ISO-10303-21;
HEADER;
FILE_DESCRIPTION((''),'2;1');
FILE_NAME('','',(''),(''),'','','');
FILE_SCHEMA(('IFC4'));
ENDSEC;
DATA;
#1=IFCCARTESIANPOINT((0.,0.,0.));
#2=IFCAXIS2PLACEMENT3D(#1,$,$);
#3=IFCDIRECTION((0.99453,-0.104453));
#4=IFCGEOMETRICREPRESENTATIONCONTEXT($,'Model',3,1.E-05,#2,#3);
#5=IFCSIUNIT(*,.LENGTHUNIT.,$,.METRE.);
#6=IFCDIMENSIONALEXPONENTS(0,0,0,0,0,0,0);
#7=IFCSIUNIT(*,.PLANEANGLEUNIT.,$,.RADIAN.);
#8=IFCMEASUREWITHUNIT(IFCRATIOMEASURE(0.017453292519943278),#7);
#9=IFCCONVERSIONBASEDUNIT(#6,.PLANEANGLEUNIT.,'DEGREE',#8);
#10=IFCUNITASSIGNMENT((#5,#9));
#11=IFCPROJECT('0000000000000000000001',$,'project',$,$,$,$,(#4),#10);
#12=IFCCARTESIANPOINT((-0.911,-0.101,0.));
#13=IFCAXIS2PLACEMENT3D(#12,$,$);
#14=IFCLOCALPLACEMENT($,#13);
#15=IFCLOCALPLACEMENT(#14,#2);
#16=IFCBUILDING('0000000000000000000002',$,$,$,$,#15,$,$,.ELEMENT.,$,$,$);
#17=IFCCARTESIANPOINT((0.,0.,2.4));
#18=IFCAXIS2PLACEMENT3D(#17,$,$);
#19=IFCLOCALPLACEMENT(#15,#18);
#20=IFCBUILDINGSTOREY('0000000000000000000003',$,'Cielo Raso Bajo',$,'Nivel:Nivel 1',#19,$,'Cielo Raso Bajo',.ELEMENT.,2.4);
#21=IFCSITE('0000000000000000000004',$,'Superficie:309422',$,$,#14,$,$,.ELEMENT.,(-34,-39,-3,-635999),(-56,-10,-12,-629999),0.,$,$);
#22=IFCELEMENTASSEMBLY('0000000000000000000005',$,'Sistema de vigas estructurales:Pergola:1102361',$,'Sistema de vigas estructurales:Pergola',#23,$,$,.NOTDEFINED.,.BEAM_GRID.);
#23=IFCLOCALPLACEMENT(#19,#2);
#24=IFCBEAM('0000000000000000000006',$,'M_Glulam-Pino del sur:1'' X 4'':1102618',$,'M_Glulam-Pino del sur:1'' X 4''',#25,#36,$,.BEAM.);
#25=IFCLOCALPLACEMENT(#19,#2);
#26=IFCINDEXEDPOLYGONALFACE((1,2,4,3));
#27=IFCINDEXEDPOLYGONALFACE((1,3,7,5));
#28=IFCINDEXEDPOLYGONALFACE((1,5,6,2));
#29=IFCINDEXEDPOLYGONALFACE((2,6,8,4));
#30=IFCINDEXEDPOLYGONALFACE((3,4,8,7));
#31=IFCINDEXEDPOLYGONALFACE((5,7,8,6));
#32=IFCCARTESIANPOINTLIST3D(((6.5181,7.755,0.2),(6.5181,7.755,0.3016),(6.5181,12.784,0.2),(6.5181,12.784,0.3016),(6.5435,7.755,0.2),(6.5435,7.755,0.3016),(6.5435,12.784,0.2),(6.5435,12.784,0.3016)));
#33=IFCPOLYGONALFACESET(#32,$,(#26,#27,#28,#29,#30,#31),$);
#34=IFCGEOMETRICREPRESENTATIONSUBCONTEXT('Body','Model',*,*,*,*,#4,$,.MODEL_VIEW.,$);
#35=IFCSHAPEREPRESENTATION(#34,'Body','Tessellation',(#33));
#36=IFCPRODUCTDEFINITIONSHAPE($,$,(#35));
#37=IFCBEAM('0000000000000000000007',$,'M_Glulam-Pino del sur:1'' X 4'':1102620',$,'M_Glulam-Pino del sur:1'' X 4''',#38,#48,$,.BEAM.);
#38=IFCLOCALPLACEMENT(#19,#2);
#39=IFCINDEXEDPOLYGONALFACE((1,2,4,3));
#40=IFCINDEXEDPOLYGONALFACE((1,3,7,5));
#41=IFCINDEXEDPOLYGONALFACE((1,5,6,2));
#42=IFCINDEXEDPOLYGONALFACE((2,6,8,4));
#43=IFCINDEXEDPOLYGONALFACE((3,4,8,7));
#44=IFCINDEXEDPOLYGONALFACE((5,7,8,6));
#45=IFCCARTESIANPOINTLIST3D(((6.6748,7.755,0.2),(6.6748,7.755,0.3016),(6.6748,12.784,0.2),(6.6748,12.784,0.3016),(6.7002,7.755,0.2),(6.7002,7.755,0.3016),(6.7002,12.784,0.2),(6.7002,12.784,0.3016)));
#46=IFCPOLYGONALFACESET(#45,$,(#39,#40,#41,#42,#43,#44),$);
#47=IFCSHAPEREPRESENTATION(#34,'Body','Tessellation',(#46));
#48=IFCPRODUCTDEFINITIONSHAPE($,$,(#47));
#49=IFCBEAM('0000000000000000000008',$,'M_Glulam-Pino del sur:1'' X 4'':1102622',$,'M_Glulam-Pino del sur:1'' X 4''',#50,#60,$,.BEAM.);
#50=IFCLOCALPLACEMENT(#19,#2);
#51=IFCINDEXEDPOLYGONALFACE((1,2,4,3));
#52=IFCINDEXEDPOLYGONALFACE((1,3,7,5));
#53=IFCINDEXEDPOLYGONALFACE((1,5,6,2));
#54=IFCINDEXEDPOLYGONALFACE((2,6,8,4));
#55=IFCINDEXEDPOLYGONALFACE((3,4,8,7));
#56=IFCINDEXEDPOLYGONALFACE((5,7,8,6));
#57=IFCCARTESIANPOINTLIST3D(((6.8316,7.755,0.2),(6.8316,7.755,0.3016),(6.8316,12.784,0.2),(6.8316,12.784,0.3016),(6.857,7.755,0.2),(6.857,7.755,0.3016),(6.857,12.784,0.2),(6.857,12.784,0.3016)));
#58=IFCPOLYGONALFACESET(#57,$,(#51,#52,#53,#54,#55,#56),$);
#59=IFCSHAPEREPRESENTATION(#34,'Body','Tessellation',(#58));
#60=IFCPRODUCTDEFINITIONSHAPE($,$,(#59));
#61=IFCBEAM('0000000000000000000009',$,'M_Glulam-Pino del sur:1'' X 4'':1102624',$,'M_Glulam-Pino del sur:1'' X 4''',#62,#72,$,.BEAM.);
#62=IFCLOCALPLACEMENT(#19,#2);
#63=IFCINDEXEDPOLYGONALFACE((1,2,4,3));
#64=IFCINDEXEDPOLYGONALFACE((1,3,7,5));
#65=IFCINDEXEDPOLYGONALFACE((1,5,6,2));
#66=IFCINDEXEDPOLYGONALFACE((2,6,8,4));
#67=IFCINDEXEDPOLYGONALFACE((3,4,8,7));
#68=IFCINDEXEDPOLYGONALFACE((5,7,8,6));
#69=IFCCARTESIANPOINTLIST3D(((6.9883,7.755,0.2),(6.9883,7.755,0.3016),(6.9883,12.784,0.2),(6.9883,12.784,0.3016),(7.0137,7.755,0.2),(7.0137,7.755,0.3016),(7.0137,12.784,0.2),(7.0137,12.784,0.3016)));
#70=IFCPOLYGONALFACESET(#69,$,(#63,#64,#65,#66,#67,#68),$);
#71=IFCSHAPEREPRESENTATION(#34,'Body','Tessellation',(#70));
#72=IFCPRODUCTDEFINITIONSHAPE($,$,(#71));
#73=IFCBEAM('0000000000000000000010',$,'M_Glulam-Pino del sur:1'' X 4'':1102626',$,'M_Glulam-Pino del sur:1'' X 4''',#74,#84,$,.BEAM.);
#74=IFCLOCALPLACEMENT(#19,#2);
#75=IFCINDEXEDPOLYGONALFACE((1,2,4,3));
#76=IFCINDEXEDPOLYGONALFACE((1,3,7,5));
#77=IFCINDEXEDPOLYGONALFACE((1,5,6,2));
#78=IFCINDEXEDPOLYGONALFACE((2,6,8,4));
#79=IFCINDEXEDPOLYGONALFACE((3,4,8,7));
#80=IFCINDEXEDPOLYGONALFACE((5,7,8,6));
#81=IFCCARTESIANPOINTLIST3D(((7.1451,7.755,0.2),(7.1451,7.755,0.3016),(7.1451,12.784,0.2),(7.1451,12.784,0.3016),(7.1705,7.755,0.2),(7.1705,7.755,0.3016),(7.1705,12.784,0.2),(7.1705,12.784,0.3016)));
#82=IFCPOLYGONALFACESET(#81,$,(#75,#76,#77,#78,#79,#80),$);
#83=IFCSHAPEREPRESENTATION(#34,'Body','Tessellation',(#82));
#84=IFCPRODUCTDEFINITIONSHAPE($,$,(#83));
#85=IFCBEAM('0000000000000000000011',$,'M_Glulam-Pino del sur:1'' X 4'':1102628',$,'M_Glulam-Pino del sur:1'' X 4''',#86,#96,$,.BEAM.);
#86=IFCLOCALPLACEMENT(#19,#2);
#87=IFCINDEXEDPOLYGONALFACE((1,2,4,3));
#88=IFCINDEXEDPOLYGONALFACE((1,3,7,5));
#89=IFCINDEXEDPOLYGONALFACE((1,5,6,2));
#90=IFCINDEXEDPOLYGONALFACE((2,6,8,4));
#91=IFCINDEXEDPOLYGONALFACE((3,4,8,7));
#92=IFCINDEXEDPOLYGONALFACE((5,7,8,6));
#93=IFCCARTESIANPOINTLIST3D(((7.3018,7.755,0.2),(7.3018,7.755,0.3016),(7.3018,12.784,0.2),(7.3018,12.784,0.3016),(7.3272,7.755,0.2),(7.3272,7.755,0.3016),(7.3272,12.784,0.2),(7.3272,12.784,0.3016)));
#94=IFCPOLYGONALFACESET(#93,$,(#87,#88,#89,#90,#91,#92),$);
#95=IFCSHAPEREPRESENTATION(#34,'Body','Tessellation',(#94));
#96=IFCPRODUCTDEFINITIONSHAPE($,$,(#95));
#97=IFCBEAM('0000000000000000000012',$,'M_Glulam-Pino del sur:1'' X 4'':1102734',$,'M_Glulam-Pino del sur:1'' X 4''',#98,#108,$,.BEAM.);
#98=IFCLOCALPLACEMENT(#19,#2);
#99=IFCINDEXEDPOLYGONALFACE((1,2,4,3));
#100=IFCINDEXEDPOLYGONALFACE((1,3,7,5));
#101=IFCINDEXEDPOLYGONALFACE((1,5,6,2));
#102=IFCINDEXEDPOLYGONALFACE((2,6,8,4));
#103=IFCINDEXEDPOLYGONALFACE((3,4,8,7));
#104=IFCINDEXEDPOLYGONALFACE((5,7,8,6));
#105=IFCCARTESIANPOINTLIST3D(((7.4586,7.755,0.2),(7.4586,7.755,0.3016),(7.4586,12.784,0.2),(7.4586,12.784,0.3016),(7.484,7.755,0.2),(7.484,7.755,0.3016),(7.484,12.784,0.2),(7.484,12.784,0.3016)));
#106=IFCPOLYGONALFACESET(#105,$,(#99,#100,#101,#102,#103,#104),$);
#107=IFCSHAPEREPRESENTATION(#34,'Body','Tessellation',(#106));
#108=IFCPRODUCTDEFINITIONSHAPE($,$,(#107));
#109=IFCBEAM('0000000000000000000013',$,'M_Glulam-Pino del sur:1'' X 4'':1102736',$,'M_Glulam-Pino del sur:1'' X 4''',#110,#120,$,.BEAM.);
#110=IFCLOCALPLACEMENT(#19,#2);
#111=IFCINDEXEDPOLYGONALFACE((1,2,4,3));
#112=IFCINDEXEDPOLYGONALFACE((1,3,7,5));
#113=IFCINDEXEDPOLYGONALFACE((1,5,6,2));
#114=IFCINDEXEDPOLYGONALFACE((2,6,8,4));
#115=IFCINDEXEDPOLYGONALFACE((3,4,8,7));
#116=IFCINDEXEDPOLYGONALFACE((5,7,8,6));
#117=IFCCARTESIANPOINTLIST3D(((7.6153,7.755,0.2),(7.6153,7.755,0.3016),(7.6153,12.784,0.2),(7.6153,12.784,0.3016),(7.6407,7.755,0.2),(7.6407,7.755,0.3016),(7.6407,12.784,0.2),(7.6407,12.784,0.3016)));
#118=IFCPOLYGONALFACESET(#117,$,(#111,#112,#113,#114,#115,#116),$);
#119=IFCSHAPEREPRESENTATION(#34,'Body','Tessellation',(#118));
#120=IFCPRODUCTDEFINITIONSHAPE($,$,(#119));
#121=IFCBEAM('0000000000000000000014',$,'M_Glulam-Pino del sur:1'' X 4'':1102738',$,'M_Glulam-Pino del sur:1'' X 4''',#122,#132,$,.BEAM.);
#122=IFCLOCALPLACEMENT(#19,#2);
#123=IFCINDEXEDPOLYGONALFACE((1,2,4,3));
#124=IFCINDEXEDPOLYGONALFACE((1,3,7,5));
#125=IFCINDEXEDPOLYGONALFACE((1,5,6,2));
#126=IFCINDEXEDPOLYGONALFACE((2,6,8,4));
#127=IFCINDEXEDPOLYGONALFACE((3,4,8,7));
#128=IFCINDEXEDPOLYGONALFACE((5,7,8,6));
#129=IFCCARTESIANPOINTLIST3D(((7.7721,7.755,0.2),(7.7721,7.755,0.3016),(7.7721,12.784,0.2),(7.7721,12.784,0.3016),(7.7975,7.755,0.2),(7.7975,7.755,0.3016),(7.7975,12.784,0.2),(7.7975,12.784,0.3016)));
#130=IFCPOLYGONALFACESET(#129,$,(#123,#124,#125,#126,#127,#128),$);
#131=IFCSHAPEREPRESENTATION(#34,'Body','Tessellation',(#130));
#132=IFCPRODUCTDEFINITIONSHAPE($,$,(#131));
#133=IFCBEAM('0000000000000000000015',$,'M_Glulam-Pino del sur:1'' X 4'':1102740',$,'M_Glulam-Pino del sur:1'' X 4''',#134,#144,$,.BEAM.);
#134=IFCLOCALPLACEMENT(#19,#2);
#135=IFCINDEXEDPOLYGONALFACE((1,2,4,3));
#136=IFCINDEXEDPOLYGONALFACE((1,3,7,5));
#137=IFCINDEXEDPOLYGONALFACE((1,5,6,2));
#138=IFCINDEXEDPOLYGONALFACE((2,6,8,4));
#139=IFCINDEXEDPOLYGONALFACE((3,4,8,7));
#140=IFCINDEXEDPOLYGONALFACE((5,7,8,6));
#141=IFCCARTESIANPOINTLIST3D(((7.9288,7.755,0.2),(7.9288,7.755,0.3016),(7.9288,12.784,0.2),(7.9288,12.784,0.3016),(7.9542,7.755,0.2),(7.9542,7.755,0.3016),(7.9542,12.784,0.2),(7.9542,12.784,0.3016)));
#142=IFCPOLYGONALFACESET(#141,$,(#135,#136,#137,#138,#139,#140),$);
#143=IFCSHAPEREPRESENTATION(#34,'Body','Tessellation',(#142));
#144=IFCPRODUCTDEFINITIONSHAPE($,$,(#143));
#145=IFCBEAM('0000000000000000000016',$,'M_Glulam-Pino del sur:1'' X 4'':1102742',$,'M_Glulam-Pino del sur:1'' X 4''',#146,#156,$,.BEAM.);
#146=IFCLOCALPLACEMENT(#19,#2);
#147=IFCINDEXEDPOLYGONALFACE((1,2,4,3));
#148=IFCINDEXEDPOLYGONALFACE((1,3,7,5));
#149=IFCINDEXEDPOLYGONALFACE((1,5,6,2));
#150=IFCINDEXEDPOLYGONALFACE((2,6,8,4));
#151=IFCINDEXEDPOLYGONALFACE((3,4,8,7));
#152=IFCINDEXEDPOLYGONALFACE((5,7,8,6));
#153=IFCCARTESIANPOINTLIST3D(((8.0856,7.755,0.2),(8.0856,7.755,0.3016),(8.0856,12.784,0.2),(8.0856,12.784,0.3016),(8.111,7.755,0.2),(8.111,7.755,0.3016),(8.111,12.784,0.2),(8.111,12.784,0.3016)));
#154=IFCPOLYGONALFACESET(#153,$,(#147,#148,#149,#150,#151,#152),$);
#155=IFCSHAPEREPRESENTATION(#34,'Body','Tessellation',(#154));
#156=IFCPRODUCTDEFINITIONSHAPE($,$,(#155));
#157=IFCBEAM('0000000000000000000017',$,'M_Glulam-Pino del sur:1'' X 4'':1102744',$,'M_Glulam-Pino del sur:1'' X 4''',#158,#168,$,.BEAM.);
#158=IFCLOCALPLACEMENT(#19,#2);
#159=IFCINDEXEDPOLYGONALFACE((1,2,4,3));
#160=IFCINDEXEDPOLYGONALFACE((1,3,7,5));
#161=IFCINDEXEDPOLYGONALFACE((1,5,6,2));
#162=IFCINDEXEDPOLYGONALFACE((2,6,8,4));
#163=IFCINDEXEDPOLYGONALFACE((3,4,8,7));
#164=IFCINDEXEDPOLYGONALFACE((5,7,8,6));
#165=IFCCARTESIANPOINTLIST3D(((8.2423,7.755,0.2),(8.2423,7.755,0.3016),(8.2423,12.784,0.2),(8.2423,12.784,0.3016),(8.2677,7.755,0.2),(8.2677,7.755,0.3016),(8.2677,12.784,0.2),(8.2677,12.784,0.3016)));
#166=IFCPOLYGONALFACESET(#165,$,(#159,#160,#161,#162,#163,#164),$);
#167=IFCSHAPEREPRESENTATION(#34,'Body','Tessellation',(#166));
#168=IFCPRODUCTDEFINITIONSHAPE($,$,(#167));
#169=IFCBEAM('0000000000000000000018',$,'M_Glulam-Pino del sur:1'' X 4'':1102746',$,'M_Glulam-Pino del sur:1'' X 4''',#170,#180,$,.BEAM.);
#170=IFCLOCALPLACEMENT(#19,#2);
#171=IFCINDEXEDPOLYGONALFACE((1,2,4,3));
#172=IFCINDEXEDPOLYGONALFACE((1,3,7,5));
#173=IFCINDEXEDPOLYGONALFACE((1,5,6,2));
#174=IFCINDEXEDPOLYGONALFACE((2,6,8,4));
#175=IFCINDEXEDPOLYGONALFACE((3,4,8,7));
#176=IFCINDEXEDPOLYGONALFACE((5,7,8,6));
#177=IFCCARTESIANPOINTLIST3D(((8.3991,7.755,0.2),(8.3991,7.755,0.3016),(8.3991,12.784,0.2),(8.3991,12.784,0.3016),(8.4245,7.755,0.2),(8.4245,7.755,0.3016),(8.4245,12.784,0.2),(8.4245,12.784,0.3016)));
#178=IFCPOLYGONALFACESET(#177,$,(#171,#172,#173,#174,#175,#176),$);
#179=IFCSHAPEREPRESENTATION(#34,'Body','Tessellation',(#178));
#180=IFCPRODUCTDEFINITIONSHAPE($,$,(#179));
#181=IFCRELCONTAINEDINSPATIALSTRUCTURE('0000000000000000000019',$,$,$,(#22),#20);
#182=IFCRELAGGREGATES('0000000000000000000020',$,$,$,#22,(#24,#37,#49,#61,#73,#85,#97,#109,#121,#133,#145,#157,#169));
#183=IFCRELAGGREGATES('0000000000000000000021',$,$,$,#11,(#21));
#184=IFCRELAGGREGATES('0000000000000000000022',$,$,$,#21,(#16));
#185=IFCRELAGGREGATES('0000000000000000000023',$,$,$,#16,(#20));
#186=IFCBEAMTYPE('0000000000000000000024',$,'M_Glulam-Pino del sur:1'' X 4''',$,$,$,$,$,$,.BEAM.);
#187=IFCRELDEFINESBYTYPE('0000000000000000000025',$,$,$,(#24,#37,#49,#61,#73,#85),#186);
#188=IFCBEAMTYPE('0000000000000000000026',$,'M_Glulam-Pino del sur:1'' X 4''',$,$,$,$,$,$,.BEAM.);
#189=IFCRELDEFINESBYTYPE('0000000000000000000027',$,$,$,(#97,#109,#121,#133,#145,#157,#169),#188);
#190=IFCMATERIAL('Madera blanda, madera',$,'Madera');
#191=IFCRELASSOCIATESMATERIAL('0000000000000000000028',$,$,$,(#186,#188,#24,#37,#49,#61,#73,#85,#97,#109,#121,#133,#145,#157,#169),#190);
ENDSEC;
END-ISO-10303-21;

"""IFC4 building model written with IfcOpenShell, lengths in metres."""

from ifc_helpers import new_model, entity, si_unit, converted_unit, direction, frame, origin, origin_2d_with_axis, place, context, subcontext, project, spatial, polyline, segment, composite_curve, rectangle, outline, extrude, source, transform, mapped, material, material_profile, profile_set, profile_usage, type_object, type_shapes, element, aggregate, save


model = new_model("IFC4")

# Units and contexts
model_context = context("Model", 3, precision=1e-05, world=origin(), true_north=direction((0.99453, -0.104453)))
body_context = subcontext(model_context, "Body", "Model", "MODEL_VIEW")
ifc_project = project(units=[si_unit("LENGTHUNIT", "METRE"), converted_unit("PLANEANGLEUNIT", "DEGREE", entity("IfcRatioMeasure", 0.017453292519943278), si_unit("PLANEANGLEUNIT", "RADIAN"), dimensions=[0, 0, 0, 0, 0, 0, 0])], contexts=[model_context])

# Site, building, storey
site_placement = place(None, frame((-0.911, -0.101, 0.0)))
site = spatial("IfcSite", under=ifc_project, at=site_placement, Name="Superficie:309422", CompositionType="ELEMENT", RefLatitude=(-34, -39, -3, -635999), RefLongitude=(-56, -10, -12, -629999), RefElevation=0.0)
building_placement = place(site_placement, origin())
building = spatial("IfcBuilding", under=site, at=building_placement, CompositionType="ELEMENT")
storey_placement = place(building_placement, frame((0.0, 0.0, 2.4)))
storey = spatial("IfcBuildingStorey", under=building, at=storey_placement, Name="Cielo Raso Bajo", ObjectType="Nivel:Nivel 1", LongName="Cielo Raso Bajo", CompositionType="ELEMENT", Elevation=2.4)

# Element assembly, beams
assembly_placement = place(storey_placement, origin())
assembly = element("IfcElementAssembly", 1, at=assembly_placement, inside=storey, Name="Sistema de vigas estructurales:Pergola:1102361", ObjectType="Sistema de vigas estructurales:Pergola", AssemblyPlace="NOTDEFINED", PredefinedType="BEAM_GRID")
ifc_material_1 = material(Name="Madera blanda, madera", Category="Madera")
ifc_material_profile_1 = material_profile(ifc_material_1, outline(composite_curve([segment(polyline([(-0.0127, 0.0508, 0.0), (0.0127, 0.0508, 0.0)]), True, "CONTINUOUS"), segment(polyline([(0.0127, 0.0508, 0.0), (0.0127, -0.0508, 0.0)]), True, "CONTINUOUS"), segment(polyline([(0.0127, -0.0508, 0.0), (-0.0127, -0.0508, 0.0)]), True, "CONTINUOUS"), segment(polyline([(-0.0127, -0.0508, 0.0), (-0.0127, 0.0508, 0.0)]), True, "CONTINUOUS")], self_intersect=False), kind="CURVE"), Name="1' X 4'")
ifc_material_profile_2 = material_profile(ifc_material_1, outline(composite_curve([segment(polyline([(2.5145, -0.0127, -0.0508), (2.5145, -0.0127, 0.0508)]), True, "CONTINUOUS"), segment(polyline([(2.5145, -0.0127, 0.0508), (-2.5145, -0.0127, 0.0508)]), True, "CONTINUOUS"), segment(polyline([(-2.5145, -0.0127, 0.0508), (-2.5145, -0.0127, -0.0508)]), True, "CONTINUOUS"), segment(polyline([(-2.5145, -0.0127, -0.0508), (2.5145, -0.0127, -0.0508)]), True, "CONTINUOUS")], self_intersect=False), kind="CURVE"), Name="1' X 4'")
ifc_profile_set_1 = profile_set([ifc_material_profile_1, ifc_material_profile_2], Name="1' X 4'")
ifc_profile_usage_1 = profile_usage(ifc_profile_set_1, cardinal=8)
beam_type_1 = type_object("IfcBeamType", Name="M_Glulam-Pino del sur:1' X 4'", PredefinedType="BEAM", material=ifc_profile_set_1)
shared_shape_1 = source(origin(), body_context, "Body", "SweptSolid", [
    extrude(rectangle(XDim=0.1016, YDim=0.0254, at=origin_2d_with_axis()), frame((-2.5145, 0.0, 0.0), z_axis=(1.0, 0.0, 0.0), x_axis=(0.0, 0.0, -1.0)), (0.0, 0.0, 1.0), 5.029),
])
type_shapes(beam_type_1, [shared_shape_1])
beam_1_placement = place(assembly_placement, frame((6.5308, 10.2695, 0.2508), z_axis=(0.0, 0.0, 1.0), x_axis=(0.0, 1.0, 0.0)))
beam_1 = element("IfcBeam", 2, at=beam_1_placement, type_object=beam_type_1, material=ifc_profile_usage_1, Name="M_Glulam-Pino del sur:1' X 4':1102618", ObjectType="M_Glulam-Pino del sur:1' X 4'", PredefinedType="BEAM", context=body_context, shape_type="MappedRepresentation", body=[
    mapped(shared_shape_1, transform((0.0, 0.0, 0.0), scale=1.0)),
])
ifc_profile_usage_2 = profile_usage(ifc_profile_set_1, cardinal=8)
beam_2_placement = place(assembly_placement, frame((6.6875, 10.2695, 0.2508), z_axis=(0.0, 0.0, 1.0), x_axis=(0.0, 1.0, 0.0)))
beam_2 = element("IfcBeam", 3, at=beam_2_placement, type_object=beam_type_1, material=ifc_profile_usage_2, Name="M_Glulam-Pino del sur:1' X 4':1102620", ObjectType="M_Glulam-Pino del sur:1' X 4'", PredefinedType="BEAM", context=body_context, shape_type="MappedRepresentation", body=[
    mapped(shared_shape_1, transform((0.0, 0.0, 0.0), scale=1.0)),
])
ifc_profile_usage_3 = profile_usage(ifc_profile_set_1, cardinal=8)
beam_3_placement = place(assembly_placement, frame((6.8443, 10.2695, 0.2508), z_axis=(0.0, 0.0, 1.0), x_axis=(0.0, 1.0, 0.0)))
beam_3 = element("IfcBeam", 4, at=beam_3_placement, type_object=beam_type_1, material=ifc_profile_usage_3, Name="M_Glulam-Pino del sur:1' X 4':1102622", ObjectType="M_Glulam-Pino del sur:1' X 4'", PredefinedType="BEAM", context=body_context, shape_type="MappedRepresentation", body=[
    mapped(shared_shape_1, transform((0.0, 0.0, 0.0), scale=1.0)),
])
ifc_profile_usage_4 = profile_usage(ifc_profile_set_1, cardinal=8)
beam_4_placement = place(assembly_placement, frame((7.001, 10.2695, 0.2508), z_axis=(0.0, 0.0, 1.0), x_axis=(0.0, 1.0, 0.0)))
beam_4 = element("IfcBeam", 5, at=beam_4_placement, type_object=beam_type_1, material=ifc_profile_usage_4, Name="M_Glulam-Pino del sur:1' X 4':1102624", ObjectType="M_Glulam-Pino del sur:1' X 4'", PredefinedType="BEAM", context=body_context, shape_type="MappedRepresentation", body=[
    mapped(shared_shape_1, transform((0.0, 0.0, 0.0), scale=1.0)),
])
ifc_profile_usage_5 = profile_usage(ifc_profile_set_1, cardinal=8)
beam_5_placement = place(assembly_placement, frame((7.1578, 10.2695, 0.2508), z_axis=(0.0, 0.0, 1.0), x_axis=(0.0, 1.0, 0.0)))
beam_5 = element("IfcBeam", 6, at=beam_5_placement, type_object=beam_type_1, material=ifc_profile_usage_5, Name="M_Glulam-Pino del sur:1' X 4':1102626", ObjectType="M_Glulam-Pino del sur:1' X 4'", PredefinedType="BEAM", context=body_context, shape_type="MappedRepresentation", body=[
    mapped(shared_shape_1, transform((0.0, 0.0, 0.0), scale=1.0)),
])
ifc_profile_usage_6 = profile_usage(ifc_profile_set_1, cardinal=8)
beam_6_placement = place(assembly_placement, frame((7.3145, 10.2695, 0.2508), z_axis=(0.0, 0.0, 1.0), x_axis=(0.0, 1.0, 0.0)))
beam_6 = element("IfcBeam", 7, at=beam_6_placement, type_object=beam_type_1, material=ifc_profile_usage_6, Name="M_Glulam-Pino del sur:1' X 4':1102628", ObjectType="M_Glulam-Pino del sur:1' X 4'", PredefinedType="BEAM", context=body_context, shape_type="MappedRepresentation", body=[
    mapped(shared_shape_1, transform((0.0, 0.0, 0.0), scale=1.0)),
])
ifc_profile_usage_7 = profile_usage(ifc_profile_set_1, cardinal=8)
beam_type_2 = type_object("IfcBeamType", Name="M_Glulam-Pino del sur:1' X 4'", PredefinedType="BEAM", material=ifc_profile_set_1)
shared_shape_2 = source(origin(), body_context, "Body", "SweptSolid", [
    extrude(rectangle(XDim=0.1016, YDim=0.0254, at=origin_2d_with_axis()), frame((-2.4455, 0.0, 0.0), z_axis=(1.0, 0.0, 0.0), x_axis=(0.0, 0.0, -1.0)), (0.0, 0.0, 1.0), 5.029),
])
type_shapes(beam_type_2, [shared_shape_2])
beam_7_placement = place(assembly_placement, frame((7.4713, 10.2005, 0.2508), z_axis=(0.0, 0.0, 1.0), x_axis=(0.0, 1.0, 0.0)))
beam_7 = element("IfcBeam", 8, at=beam_7_placement, type_object=beam_type_2, material=ifc_profile_usage_7, Name="M_Glulam-Pino del sur:1' X 4':1102734", ObjectType="M_Glulam-Pino del sur:1' X 4'", PredefinedType="BEAM", context=body_context, shape_type="MappedRepresentation", body=[
    mapped(shared_shape_2, transform((0.0, 0.0, 0.0), scale=1.0)),
])
ifc_profile_usage_8 = profile_usage(ifc_profile_set_1, cardinal=8)
beam_8_placement = place(assembly_placement, frame((7.628, 10.2005, 0.2508), z_axis=(0.0, 0.0, 1.0), x_axis=(0.0, 1.0, 0.0)))
beam_8 = element("IfcBeam", 9, at=beam_8_placement, type_object=beam_type_2, material=ifc_profile_usage_8, Name="M_Glulam-Pino del sur:1' X 4':1102736", ObjectType="M_Glulam-Pino del sur:1' X 4'", PredefinedType="BEAM", context=body_context, shape_type="MappedRepresentation", body=[
    mapped(shared_shape_2, transform((0.0, 0.0, 0.0), scale=1.0)),
])
ifc_profile_usage_9 = profile_usage(ifc_profile_set_1, cardinal=8)
beam_9_placement = place(assembly_placement, frame((7.7848, 10.2005, 0.2508), z_axis=(0.0, 0.0, 1.0), x_axis=(0.0, 1.0, 0.0)))
beam_9 = element("IfcBeam", 10, at=beam_9_placement, type_object=beam_type_2, material=ifc_profile_usage_9, Name="M_Glulam-Pino del sur:1' X 4':1102738", ObjectType="M_Glulam-Pino del sur:1' X 4'", PredefinedType="BEAM", context=body_context, shape_type="MappedRepresentation", body=[
    mapped(shared_shape_2, transform((0.0, 0.0, 0.0), scale=1.0)),
])
ifc_profile_usage_10 = profile_usage(ifc_profile_set_1, cardinal=8)
beam_10_placement = place(assembly_placement, frame((7.9415, 10.2005, 0.2508), z_axis=(0.0, 0.0, 1.0), x_axis=(0.0, 1.0, 0.0)))
beam_10 = element("IfcBeam", 11, at=beam_10_placement, type_object=beam_type_2, material=ifc_profile_usage_10, Name="M_Glulam-Pino del sur:1' X 4':1102740", ObjectType="M_Glulam-Pino del sur:1' X 4'", PredefinedType="BEAM", context=body_context, shape_type="MappedRepresentation", body=[
    mapped(shared_shape_2, transform((0.0, 0.0, 0.0), scale=1.0)),
])
ifc_profile_usage_11 = profile_usage(ifc_profile_set_1, cardinal=8)
beam_11_placement = place(assembly_placement, frame((8.0983, 10.2005, 0.2508), z_axis=(0.0, 0.0, 1.0), x_axis=(0.0, 1.0, 0.0)))
beam_11 = element("IfcBeam", 12, at=beam_11_placement, type_object=beam_type_2, material=ifc_profile_usage_11, Name="M_Glulam-Pino del sur:1' X 4':1102742", ObjectType="M_Glulam-Pino del sur:1' X 4'", PredefinedType="BEAM", context=body_context, shape_type="MappedRepresentation", body=[
    mapped(shared_shape_2, transform((0.0, 0.0, 0.0), scale=1.0)),
])
ifc_profile_usage_12 = profile_usage(ifc_profile_set_1, cardinal=8)
beam_12_placement = place(assembly_placement, frame((8.255, 10.2005, 0.2508), z_axis=(0.0, 0.0, 1.0), x_axis=(0.0, 1.0, 0.0)))
beam_12 = element("IfcBeam", 13, at=beam_12_placement, type_object=beam_type_2, material=ifc_profile_usage_12, Name="M_Glulam-Pino del sur:1' X 4':1102744", ObjectType="M_Glulam-Pino del sur:1' X 4'", PredefinedType="BEAM", context=body_context, shape_type="MappedRepresentation", body=[
    mapped(shared_shape_2, transform((0.0, 0.0, 0.0), scale=1.0)),
])
ifc_profile_usage_13 = profile_usage(ifc_profile_set_1, cardinal=8)
beam_13_placement = place(assembly_placement, frame((8.4118, 10.2005, 0.2508), z_axis=(0.0, 0.0, 1.0), x_axis=(0.0, 1.0, 0.0)))
beam_13 = element("IfcBeam", 14, at=beam_13_placement, type_object=beam_type_2, material=ifc_profile_usage_13, Name="M_Glulam-Pino del sur:1' X 4':1102746", ObjectType="M_Glulam-Pino del sur:1' X 4'", PredefinedType="BEAM", context=body_context, shape_type="MappedRepresentation", body=[
    mapped(shared_shape_2, transform((0.0, 0.0, 0.0), scale=1.0)),
])
aggregate(assembly, [beam_1, beam_2, beam_3, beam_4, beam_5, beam_6, beam_7, beam_8, beam_9, beam_10, beam_11, beam_12, beam_13])

save(model, "model.ifc")
